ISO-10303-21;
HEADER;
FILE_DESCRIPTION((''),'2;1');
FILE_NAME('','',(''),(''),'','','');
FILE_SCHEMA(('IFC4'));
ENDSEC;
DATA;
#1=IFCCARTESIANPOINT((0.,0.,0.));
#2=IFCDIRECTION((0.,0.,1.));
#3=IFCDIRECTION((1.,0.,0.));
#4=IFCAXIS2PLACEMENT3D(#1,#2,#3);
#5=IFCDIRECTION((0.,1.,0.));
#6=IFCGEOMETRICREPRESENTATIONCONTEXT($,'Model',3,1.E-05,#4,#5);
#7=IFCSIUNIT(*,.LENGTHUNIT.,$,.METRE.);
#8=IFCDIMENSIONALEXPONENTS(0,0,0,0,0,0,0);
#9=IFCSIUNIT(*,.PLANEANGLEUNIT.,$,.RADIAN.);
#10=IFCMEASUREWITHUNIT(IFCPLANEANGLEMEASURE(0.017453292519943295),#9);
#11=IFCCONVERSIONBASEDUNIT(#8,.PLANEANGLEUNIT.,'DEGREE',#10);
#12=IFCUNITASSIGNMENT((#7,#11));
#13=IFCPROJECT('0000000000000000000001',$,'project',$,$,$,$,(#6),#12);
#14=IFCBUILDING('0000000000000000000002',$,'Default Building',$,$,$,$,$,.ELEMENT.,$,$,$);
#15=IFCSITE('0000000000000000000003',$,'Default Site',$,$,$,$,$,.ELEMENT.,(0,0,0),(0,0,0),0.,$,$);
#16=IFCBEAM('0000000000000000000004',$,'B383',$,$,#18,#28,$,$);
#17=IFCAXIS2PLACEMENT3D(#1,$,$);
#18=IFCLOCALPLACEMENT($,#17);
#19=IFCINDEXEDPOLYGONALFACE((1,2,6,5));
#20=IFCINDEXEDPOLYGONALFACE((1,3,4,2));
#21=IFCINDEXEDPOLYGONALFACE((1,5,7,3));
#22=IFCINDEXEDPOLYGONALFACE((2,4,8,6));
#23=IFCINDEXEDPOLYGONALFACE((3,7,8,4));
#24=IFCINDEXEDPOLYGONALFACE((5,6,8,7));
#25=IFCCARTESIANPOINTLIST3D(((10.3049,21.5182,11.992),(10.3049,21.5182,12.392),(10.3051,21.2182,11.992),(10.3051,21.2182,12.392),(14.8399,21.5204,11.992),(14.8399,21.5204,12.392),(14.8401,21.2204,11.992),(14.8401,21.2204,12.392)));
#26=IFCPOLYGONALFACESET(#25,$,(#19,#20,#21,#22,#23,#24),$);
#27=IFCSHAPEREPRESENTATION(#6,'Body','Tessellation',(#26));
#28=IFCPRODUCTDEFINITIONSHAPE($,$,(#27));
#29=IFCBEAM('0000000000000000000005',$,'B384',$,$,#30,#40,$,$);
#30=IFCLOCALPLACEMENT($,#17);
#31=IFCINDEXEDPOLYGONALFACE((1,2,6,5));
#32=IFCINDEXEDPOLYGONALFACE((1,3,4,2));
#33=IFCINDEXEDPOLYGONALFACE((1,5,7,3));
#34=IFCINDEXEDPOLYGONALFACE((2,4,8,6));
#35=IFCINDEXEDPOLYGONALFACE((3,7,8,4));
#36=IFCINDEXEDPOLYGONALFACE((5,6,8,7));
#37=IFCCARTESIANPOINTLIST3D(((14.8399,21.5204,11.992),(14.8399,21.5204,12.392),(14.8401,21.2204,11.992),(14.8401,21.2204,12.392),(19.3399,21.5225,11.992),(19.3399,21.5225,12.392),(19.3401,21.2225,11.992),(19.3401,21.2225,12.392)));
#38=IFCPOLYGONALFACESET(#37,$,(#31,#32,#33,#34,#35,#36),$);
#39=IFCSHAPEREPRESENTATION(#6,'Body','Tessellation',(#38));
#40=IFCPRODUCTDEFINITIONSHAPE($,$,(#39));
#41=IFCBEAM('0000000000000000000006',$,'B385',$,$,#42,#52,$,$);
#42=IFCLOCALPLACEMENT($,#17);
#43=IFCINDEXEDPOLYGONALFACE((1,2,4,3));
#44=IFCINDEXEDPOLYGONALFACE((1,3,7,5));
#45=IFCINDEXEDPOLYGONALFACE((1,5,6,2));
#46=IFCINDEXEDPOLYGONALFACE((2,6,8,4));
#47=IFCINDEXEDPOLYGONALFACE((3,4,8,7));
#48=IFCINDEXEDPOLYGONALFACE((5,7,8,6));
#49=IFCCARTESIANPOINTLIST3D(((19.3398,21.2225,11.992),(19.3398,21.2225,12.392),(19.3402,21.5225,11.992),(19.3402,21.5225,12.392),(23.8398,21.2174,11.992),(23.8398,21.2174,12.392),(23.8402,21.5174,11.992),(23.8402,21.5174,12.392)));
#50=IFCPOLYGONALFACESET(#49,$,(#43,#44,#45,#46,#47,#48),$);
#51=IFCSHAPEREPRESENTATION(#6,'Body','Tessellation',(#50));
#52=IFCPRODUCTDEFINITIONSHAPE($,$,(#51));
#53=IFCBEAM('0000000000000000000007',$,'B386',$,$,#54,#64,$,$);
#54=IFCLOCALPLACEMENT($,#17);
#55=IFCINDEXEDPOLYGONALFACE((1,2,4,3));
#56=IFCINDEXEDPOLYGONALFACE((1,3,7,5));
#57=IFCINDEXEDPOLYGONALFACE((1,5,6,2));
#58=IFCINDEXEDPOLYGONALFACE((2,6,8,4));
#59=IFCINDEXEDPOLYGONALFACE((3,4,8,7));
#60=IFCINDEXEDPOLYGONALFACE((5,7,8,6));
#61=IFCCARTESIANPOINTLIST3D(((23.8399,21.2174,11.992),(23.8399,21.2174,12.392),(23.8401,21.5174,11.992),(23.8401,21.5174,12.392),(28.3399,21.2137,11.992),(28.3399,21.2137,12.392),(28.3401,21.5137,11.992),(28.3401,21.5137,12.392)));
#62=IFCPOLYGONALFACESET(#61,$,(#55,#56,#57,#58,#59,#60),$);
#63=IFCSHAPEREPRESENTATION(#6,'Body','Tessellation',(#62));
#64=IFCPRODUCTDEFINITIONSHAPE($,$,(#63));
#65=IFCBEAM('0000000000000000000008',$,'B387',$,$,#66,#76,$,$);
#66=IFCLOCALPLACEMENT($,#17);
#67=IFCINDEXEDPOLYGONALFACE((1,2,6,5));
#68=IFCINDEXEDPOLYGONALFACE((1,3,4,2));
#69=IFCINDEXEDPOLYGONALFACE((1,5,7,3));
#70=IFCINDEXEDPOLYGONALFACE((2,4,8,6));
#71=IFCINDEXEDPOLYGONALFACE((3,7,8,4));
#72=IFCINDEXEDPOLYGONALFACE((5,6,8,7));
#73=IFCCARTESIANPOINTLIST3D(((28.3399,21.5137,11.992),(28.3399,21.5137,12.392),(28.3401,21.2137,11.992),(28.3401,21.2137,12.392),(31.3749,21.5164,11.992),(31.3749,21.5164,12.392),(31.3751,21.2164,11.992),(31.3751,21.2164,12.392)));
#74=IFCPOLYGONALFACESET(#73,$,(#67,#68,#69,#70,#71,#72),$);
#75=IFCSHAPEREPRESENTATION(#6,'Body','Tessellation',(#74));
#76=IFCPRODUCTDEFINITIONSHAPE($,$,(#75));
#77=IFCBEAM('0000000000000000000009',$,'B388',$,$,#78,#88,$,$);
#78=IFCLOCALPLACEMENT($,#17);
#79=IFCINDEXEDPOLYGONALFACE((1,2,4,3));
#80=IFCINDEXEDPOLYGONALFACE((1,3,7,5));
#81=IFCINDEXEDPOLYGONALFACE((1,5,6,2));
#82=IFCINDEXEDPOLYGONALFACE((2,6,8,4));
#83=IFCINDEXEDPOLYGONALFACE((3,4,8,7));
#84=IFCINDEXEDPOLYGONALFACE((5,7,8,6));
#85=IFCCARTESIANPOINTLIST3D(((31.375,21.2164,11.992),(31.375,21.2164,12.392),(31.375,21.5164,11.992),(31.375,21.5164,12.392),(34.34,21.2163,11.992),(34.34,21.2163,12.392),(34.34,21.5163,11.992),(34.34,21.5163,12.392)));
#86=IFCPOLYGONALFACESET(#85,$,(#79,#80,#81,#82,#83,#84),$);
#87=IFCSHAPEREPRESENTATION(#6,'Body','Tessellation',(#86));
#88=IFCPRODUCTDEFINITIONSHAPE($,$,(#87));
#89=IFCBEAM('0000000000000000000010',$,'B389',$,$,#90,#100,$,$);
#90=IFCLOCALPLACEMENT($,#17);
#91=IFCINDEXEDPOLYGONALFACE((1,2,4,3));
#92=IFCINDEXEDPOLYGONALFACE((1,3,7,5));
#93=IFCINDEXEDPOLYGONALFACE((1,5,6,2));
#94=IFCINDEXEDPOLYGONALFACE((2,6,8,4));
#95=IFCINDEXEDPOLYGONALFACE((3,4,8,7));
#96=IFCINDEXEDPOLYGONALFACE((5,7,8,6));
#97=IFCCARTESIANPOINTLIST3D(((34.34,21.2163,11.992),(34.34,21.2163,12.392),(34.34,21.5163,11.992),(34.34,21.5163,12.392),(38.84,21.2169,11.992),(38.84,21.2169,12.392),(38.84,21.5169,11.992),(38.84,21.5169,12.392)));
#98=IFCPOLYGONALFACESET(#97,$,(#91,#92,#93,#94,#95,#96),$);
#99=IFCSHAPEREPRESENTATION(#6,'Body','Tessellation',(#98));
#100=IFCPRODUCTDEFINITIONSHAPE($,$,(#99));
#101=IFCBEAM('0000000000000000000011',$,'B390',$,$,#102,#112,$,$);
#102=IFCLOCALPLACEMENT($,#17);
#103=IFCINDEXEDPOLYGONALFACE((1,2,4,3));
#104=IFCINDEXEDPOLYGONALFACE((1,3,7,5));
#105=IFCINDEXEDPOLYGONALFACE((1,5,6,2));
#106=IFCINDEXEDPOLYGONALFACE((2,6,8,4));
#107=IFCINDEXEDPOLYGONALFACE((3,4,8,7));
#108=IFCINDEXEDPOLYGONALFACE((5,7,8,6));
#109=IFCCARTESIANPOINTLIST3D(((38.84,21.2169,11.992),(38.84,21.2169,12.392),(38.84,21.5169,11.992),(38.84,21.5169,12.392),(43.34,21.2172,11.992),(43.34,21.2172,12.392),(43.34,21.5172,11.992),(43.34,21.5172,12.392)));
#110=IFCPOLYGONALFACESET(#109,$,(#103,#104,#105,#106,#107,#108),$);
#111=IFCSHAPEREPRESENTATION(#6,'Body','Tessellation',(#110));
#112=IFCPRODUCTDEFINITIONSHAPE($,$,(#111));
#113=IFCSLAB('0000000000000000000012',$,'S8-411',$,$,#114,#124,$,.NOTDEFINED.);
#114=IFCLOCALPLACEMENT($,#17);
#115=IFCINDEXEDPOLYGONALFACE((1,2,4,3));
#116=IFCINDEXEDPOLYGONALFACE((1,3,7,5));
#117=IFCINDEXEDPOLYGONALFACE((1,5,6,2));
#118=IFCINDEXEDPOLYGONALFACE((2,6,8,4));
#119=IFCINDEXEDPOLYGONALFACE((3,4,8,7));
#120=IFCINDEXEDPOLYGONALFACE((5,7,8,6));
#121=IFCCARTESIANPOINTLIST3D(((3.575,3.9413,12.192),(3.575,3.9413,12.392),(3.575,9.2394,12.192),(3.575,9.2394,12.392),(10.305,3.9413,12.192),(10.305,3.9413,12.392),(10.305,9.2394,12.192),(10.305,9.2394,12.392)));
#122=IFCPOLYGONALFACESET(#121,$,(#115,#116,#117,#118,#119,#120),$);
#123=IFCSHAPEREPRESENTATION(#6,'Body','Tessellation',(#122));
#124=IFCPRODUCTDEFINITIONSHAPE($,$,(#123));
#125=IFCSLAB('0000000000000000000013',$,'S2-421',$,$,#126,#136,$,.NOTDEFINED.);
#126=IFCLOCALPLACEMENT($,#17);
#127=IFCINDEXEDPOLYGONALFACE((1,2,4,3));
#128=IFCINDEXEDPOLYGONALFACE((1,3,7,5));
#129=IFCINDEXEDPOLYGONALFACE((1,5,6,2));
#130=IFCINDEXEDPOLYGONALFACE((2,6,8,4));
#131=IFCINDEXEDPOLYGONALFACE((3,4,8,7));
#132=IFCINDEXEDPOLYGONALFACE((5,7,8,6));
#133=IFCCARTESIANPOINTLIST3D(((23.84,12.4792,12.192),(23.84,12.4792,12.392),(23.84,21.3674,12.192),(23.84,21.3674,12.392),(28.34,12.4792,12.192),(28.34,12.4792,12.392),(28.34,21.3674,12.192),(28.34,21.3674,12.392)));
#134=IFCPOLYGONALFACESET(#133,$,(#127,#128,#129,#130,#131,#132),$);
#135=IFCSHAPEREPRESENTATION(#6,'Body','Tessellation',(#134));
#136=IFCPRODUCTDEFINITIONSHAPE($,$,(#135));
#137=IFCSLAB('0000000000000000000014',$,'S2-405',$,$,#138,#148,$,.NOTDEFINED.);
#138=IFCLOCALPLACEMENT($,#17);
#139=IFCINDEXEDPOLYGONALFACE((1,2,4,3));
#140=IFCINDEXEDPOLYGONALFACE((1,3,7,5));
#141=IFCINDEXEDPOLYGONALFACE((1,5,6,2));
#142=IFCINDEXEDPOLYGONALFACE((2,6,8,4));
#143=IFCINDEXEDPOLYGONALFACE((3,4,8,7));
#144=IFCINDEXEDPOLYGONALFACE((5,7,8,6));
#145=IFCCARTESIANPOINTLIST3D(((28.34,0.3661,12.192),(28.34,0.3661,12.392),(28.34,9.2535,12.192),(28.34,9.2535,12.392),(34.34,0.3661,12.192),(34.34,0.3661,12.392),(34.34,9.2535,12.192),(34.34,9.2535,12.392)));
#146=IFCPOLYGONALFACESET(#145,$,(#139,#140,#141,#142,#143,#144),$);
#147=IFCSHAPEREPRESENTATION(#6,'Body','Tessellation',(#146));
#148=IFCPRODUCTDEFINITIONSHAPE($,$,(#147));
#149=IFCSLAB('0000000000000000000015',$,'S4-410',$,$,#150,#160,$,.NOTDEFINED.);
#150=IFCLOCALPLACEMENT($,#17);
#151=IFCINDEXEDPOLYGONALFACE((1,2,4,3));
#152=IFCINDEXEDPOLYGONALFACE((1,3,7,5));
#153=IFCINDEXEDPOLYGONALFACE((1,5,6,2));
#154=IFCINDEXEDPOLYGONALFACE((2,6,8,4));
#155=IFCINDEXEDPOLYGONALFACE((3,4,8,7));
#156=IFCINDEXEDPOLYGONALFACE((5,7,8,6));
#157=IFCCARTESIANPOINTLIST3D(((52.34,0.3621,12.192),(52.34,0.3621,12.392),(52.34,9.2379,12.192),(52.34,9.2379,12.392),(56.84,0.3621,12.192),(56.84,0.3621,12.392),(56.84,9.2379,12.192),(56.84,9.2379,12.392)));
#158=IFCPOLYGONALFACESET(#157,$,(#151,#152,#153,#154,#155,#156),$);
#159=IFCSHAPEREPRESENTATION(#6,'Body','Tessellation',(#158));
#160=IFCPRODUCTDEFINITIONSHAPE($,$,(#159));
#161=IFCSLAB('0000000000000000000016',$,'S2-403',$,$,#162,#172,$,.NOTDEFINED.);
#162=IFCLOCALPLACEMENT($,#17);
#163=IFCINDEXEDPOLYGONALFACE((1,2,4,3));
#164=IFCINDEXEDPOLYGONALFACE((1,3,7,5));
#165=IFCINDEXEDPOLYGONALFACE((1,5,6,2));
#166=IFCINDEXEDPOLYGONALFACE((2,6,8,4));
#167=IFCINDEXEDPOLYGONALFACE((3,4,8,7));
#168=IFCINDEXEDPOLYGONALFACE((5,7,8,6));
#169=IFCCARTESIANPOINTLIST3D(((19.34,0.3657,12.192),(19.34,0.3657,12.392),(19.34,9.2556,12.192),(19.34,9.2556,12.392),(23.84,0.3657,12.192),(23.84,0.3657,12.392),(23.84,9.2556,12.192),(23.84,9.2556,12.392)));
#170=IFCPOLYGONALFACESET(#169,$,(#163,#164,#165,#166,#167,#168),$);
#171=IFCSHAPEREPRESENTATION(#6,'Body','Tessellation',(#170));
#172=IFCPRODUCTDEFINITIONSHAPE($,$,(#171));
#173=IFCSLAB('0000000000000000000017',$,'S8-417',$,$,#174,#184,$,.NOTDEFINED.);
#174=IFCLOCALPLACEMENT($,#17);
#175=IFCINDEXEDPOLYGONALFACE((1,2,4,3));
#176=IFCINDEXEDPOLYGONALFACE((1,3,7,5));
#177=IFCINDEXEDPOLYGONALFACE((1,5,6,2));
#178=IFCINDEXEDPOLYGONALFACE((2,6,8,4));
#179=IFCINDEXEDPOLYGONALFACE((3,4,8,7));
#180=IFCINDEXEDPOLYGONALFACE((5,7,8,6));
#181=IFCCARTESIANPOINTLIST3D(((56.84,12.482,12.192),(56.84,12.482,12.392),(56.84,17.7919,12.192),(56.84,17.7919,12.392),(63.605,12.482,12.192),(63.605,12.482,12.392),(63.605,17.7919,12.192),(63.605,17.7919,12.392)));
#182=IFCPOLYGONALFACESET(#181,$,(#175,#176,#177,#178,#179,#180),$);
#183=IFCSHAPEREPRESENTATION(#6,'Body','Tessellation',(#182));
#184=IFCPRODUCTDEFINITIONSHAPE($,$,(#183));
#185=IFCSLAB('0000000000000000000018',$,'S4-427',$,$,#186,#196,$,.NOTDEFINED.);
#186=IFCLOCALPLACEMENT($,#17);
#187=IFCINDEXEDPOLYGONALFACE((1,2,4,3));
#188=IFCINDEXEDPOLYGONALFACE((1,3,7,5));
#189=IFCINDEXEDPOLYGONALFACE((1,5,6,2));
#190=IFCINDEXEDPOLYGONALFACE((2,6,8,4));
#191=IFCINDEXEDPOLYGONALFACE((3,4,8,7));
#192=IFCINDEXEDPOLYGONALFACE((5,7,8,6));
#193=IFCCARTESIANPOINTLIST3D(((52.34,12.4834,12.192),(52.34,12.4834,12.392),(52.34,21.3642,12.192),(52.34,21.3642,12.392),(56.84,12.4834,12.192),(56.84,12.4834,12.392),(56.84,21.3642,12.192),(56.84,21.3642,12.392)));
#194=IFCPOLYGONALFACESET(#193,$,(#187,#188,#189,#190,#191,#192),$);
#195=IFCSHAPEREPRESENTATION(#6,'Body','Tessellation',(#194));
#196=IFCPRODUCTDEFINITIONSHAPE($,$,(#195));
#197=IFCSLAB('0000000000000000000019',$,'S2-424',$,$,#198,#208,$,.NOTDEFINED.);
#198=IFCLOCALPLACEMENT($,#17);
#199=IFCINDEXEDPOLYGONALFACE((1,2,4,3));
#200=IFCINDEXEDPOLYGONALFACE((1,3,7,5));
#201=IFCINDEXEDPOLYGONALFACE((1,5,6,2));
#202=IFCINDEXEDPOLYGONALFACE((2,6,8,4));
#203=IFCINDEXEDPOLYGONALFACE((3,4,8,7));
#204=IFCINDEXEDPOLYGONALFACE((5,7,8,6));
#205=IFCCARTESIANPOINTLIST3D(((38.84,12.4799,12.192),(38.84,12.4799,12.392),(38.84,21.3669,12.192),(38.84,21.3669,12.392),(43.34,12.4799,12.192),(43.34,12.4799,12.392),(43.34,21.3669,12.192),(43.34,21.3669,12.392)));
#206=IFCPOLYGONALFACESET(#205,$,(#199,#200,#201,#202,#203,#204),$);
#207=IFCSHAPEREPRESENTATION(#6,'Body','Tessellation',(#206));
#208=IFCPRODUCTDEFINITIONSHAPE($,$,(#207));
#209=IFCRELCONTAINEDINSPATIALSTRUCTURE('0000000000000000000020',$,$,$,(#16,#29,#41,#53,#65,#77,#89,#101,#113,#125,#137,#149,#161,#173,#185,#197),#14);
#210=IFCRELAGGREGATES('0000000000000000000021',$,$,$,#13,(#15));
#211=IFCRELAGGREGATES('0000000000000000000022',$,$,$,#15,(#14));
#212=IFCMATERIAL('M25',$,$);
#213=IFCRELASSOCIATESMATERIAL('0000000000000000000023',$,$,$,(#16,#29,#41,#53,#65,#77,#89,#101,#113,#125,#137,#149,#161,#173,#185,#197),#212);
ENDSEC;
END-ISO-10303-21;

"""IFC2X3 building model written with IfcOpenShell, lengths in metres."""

from ifc_helpers import new_model, entity, si_unit, converted_unit, direction, frame, frame_2d, origin_with_axes, place, context, project, spatial, rectangle, extrude, material, element, save


model = new_model("IFC2X3")

# Units and contexts
model_context = context("Model", 3, precision=1e-05, world=origin_with_axes(), true_north=direction((0.0, 1.0, 0.0)))
ifc_project = project(units=[si_unit("LENGTHUNIT", "METRE"), converted_unit("PLANEANGLEUNIT", "DEGREE", entity("IfcPlaneAngleMeasure", 0.017453292519943295), si_unit("PLANEANGLEUNIT", "RADIAN"), dimensions=[0, 0, 0, 0, 0, 0, 0])], contexts=[model_context])

# Site, building
site = spatial("IfcSite", under=ifc_project, Name="Default Site", CompositionType="ELEMENT", RefLatitude=(0, 0, 0), RefLongitude=(0, 0, 0), RefElevation=0.0)
building = spatial("IfcBuilding", under=site, Name="Default Building", CompositionType="ELEMENT")

# Beams
ifc_material = material(Name="M25")
placement = place(None, origin_with_axes())
element("IfcBeam", 1, at=placement, inside=building, material=ifc_material, Name="B383", context=model_context, shape_type="SweptSolid", body=[
    extrude(rectangle(XDim=0.3, YDim=0.4, at=frame_2d((0.0, 0.0), x_axis=(0.0, 1.0, 0.0))), frame((10.305, 21.3682, 12.192), z_axis=(1.0, 0.000476, 0.0), x_axis=(0.0, 0.0, -1.0)), (0.0, 0.0, 1.0), 4.535),
])
element("IfcBeam", 2, at=placement, inside=building, material=ifc_material, Name="B384", context=model_context, shape_type="SweptSolid", body=[
    extrude(rectangle(XDim=0.3, YDim=0.4, at=frame_2d((0.0, 0.0), x_axis=(0.0, 1.0, 0.0))), frame((14.84, 21.3704, 12.192), z_axis=(1.0, 0.000471, 0.0), x_axis=(0.0, 0.0, -1.0)), (0.0, 0.0, 1.0), 4.5),
])
element("IfcBeam", 3, at=placement, inside=building, material=ifc_material, Name="B385", context=model_context, shape_type="SweptSolid", body=[
    extrude(rectangle(XDim=0.3, YDim=0.4, at=frame_2d((0.0, 0.0), x_axis=(0.0, 1.0, 0.0))), frame((19.34, 21.3725, 12.192), z_axis=(0.999999, -0.001141, 0.0), x_axis=(0.0, 0.0, -1.0)), (0.0, 0.0, 1.0), 4.5),
])
element("IfcBeam", 4, at=placement, inside=building, material=ifc_material, Name="B386", context=model_context, shape_type="SweptSolid", body=[
    extrude(rectangle(XDim=0.3, YDim=0.4, at=frame_2d((0.0, 0.0), x_axis=(0.0, 1.0, 0.0))), frame((23.84, 21.3674, 12.192), z_axis=(1.0, -0.000812, 0.0), x_axis=(0.0, 0.0, -1.0)), (0.0, 0.0, 1.0), 4.5),
])
element("IfcBeam", 5, at=placement, inside=building, material=ifc_material, Name="B387", context=model_context, shape_type="SweptSolid", body=[
    extrude(rectangle(XDim=0.3, YDim=0.4, at=frame_2d((0.0, 0.0), x_axis=(0.0, 1.0, 0.0))), frame((28.34, 21.3637, 12.192), z_axis=(1.0, 0.000883, 0.0), x_axis=(0.0, 0.0, -1.0)), (0.0, 0.0, 1.0), 3.035),
])
element("IfcBeam", 6, at=placement, inside=building, material=ifc_material, Name="B388", context=model_context, shape_type="SweptSolid", body=[
    extrude(rectangle(XDim=0.3, YDim=0.4, at=frame_2d((0.0, 0.0), x_axis=(0.0, 1.0, 0.0))), frame((31.375, 21.3664, 12.192), z_axis=(1.0, -0.000016, 0.0), x_axis=(0.0, 0.0, -1.0)), (0.0, 0.0, 1.0), 2.965),
])
element("IfcBeam", 7, at=placement, inside=building, material=ifc_material, Name="B389", context=model_context, shape_type="SweptSolid", body=[
    extrude(rectangle(XDim=0.3, YDim=0.4, at=frame_2d((0.0, 0.0), x_axis=(0.0, 1.0, 0.0))), frame((34.34, 21.3663, 12.192), z_axis=(1.0, 0.000136, 0.0), x_axis=(0.0, 0.0, -1.0)), (0.0, 0.0, 1.0), 4.5),
])
element("IfcBeam", 8, at=placement, inside=building, material=ifc_material, Name="B390", context=model_context, shape_type="SweptSolid", body=[
    extrude(rectangle(XDim=0.3, YDim=0.4, at=frame_2d((0.0, 0.0), x_axis=(0.0, 1.0, 0.0))), frame((38.84, 21.3669, 12.192), z_axis=(1.0, 0.00005, 0.0), x_axis=(0.0, 0.0, -1.0)), (0.0, 0.0, 1.0), 4.5),
])

# Slabs
element("IfcSlab", 9, at=placement, inside=building, material=ifc_material, Name="S8-411", PredefinedType="NOTDEFINED", context=model_context, shape_type="SweptSolid", body=[
    extrude(rectangle(XDim=6.73, YDim=5.2982, at=frame_2d((0.0, 0.0), x_axis=(1.0, 0.0, 0.0))), frame((6.94, 6.5903, 12.192), z_axis=(0.0, 0.0, 1.0), x_axis=(1.0, 0.0, 0.0)), (0.0, 0.0, 1.0), 0.2),
])
element("IfcSlab", 10, at=placement, inside=building, material=ifc_material, Name="S2-421", PredefinedType="NOTDEFINED", context=model_context, shape_type="SweptSolid", body=[
    extrude(rectangle(XDim=4.5, YDim=8.8882, at=frame_2d((0.0, 0.0), x_axis=(1.0, 0.0, 0.0))), frame((26.09, 16.9233, 12.192), z_axis=(0.0, 0.0, 1.0), x_axis=(1.0, 0.0, 0.0)), (0.0, 0.0, 1.0), 0.2),
])
element("IfcSlab", 11, at=placement, inside=building, material=ifc_material, Name="S2-405", PredefinedType="NOTDEFINED", context=model_context, shape_type="SweptSolid", body=[
    extrude(rectangle(XDim=6.0, YDim=8.8874, at=frame_2d((0.0, 0.0), x_axis=(1.0, 0.0, 0.0))), frame((31.34, 4.8098, 12.192), z_axis=(0.0, 0.0, 1.0), x_axis=(1.0, 0.0, 0.0)), (0.0, 0.0, 1.0), 0.2),
])
element("IfcSlab", 12, at=placement, inside=building, material=ifc_material, Name="S4-410", PredefinedType="NOTDEFINED", context=model_context, shape_type="SweptSolid", body=[
    extrude(rectangle(XDim=4.5, YDim=8.8758, at=frame_2d((0.0, 0.0), x_axis=(1.0, 0.0, 0.0))), frame((54.59, 4.8, 12.192), z_axis=(0.0, 0.0, 1.0), x_axis=(1.0, 0.0, 0.0)), (0.0, 0.0, 1.0), 0.2),
])
element("IfcSlab", 13, at=placement, inside=building, material=ifc_material, Name="S2-403", PredefinedType="NOTDEFINED", context=model_context, shape_type="SweptSolid", body=[
    extrude(rectangle(XDim=4.5, YDim=8.89, at=frame_2d((0.0, 0.0), x_axis=(1.0, 0.0, 0.0))), frame((21.59, 4.8106, 12.192), z_axis=(0.0, 0.0, 1.0), x_axis=(1.0, 0.0, 0.0)), (0.0, 0.0, 1.0), 0.2),
])
element("IfcSlab", 14, at=placement, inside=building, material=ifc_material, Name="S8-417", PredefinedType="NOTDEFINED", context=model_context, shape_type="SweptSolid", body=[
    extrude(rectangle(XDim=6.765, YDim=5.3099, at=frame_2d((0.0, 0.0), x_axis=(1.0, 0.0, 0.0))), frame((60.2225, 15.1369, 12.192), z_axis=(0.0, 0.0, 1.0), x_axis=(1.0, 0.0, 0.0)), (0.0, 0.0, 1.0), 0.2),
])
element("IfcSlab", 15, at=placement, inside=building, material=ifc_material, Name="S4-427", PredefinedType="NOTDEFINED", context=model_context, shape_type="SweptSolid", body=[
    extrude(rectangle(XDim=4.5, YDim=8.8807, at=frame_2d((0.0, 0.0), x_axis=(1.0, 0.0, 0.0))), frame((54.59, 16.9238, 12.192), z_axis=(0.0, 0.0, 1.0), x_axis=(1.0, 0.0, 0.0)), (0.0, 0.0, 1.0), 0.2),
])
element("IfcSlab", 16, at=placement, inside=building, material=ifc_material, Name="S2-424", PredefinedType="NOTDEFINED", context=model_context, shape_type="SweptSolid", body=[
    extrude(rectangle(XDim=4.5, YDim=8.8871, at=frame_2d((0.0, 0.0), x_axis=(1.0, 0.0, 0.0))), frame((41.09, 16.9234, 12.192), z_axis=(0.0, 0.0, 1.0), x_axis=(1.0, 0.0, 0.0)), (0.0, 0.0, 1.0), 0.2),
])

save(model, "model.ifc")
